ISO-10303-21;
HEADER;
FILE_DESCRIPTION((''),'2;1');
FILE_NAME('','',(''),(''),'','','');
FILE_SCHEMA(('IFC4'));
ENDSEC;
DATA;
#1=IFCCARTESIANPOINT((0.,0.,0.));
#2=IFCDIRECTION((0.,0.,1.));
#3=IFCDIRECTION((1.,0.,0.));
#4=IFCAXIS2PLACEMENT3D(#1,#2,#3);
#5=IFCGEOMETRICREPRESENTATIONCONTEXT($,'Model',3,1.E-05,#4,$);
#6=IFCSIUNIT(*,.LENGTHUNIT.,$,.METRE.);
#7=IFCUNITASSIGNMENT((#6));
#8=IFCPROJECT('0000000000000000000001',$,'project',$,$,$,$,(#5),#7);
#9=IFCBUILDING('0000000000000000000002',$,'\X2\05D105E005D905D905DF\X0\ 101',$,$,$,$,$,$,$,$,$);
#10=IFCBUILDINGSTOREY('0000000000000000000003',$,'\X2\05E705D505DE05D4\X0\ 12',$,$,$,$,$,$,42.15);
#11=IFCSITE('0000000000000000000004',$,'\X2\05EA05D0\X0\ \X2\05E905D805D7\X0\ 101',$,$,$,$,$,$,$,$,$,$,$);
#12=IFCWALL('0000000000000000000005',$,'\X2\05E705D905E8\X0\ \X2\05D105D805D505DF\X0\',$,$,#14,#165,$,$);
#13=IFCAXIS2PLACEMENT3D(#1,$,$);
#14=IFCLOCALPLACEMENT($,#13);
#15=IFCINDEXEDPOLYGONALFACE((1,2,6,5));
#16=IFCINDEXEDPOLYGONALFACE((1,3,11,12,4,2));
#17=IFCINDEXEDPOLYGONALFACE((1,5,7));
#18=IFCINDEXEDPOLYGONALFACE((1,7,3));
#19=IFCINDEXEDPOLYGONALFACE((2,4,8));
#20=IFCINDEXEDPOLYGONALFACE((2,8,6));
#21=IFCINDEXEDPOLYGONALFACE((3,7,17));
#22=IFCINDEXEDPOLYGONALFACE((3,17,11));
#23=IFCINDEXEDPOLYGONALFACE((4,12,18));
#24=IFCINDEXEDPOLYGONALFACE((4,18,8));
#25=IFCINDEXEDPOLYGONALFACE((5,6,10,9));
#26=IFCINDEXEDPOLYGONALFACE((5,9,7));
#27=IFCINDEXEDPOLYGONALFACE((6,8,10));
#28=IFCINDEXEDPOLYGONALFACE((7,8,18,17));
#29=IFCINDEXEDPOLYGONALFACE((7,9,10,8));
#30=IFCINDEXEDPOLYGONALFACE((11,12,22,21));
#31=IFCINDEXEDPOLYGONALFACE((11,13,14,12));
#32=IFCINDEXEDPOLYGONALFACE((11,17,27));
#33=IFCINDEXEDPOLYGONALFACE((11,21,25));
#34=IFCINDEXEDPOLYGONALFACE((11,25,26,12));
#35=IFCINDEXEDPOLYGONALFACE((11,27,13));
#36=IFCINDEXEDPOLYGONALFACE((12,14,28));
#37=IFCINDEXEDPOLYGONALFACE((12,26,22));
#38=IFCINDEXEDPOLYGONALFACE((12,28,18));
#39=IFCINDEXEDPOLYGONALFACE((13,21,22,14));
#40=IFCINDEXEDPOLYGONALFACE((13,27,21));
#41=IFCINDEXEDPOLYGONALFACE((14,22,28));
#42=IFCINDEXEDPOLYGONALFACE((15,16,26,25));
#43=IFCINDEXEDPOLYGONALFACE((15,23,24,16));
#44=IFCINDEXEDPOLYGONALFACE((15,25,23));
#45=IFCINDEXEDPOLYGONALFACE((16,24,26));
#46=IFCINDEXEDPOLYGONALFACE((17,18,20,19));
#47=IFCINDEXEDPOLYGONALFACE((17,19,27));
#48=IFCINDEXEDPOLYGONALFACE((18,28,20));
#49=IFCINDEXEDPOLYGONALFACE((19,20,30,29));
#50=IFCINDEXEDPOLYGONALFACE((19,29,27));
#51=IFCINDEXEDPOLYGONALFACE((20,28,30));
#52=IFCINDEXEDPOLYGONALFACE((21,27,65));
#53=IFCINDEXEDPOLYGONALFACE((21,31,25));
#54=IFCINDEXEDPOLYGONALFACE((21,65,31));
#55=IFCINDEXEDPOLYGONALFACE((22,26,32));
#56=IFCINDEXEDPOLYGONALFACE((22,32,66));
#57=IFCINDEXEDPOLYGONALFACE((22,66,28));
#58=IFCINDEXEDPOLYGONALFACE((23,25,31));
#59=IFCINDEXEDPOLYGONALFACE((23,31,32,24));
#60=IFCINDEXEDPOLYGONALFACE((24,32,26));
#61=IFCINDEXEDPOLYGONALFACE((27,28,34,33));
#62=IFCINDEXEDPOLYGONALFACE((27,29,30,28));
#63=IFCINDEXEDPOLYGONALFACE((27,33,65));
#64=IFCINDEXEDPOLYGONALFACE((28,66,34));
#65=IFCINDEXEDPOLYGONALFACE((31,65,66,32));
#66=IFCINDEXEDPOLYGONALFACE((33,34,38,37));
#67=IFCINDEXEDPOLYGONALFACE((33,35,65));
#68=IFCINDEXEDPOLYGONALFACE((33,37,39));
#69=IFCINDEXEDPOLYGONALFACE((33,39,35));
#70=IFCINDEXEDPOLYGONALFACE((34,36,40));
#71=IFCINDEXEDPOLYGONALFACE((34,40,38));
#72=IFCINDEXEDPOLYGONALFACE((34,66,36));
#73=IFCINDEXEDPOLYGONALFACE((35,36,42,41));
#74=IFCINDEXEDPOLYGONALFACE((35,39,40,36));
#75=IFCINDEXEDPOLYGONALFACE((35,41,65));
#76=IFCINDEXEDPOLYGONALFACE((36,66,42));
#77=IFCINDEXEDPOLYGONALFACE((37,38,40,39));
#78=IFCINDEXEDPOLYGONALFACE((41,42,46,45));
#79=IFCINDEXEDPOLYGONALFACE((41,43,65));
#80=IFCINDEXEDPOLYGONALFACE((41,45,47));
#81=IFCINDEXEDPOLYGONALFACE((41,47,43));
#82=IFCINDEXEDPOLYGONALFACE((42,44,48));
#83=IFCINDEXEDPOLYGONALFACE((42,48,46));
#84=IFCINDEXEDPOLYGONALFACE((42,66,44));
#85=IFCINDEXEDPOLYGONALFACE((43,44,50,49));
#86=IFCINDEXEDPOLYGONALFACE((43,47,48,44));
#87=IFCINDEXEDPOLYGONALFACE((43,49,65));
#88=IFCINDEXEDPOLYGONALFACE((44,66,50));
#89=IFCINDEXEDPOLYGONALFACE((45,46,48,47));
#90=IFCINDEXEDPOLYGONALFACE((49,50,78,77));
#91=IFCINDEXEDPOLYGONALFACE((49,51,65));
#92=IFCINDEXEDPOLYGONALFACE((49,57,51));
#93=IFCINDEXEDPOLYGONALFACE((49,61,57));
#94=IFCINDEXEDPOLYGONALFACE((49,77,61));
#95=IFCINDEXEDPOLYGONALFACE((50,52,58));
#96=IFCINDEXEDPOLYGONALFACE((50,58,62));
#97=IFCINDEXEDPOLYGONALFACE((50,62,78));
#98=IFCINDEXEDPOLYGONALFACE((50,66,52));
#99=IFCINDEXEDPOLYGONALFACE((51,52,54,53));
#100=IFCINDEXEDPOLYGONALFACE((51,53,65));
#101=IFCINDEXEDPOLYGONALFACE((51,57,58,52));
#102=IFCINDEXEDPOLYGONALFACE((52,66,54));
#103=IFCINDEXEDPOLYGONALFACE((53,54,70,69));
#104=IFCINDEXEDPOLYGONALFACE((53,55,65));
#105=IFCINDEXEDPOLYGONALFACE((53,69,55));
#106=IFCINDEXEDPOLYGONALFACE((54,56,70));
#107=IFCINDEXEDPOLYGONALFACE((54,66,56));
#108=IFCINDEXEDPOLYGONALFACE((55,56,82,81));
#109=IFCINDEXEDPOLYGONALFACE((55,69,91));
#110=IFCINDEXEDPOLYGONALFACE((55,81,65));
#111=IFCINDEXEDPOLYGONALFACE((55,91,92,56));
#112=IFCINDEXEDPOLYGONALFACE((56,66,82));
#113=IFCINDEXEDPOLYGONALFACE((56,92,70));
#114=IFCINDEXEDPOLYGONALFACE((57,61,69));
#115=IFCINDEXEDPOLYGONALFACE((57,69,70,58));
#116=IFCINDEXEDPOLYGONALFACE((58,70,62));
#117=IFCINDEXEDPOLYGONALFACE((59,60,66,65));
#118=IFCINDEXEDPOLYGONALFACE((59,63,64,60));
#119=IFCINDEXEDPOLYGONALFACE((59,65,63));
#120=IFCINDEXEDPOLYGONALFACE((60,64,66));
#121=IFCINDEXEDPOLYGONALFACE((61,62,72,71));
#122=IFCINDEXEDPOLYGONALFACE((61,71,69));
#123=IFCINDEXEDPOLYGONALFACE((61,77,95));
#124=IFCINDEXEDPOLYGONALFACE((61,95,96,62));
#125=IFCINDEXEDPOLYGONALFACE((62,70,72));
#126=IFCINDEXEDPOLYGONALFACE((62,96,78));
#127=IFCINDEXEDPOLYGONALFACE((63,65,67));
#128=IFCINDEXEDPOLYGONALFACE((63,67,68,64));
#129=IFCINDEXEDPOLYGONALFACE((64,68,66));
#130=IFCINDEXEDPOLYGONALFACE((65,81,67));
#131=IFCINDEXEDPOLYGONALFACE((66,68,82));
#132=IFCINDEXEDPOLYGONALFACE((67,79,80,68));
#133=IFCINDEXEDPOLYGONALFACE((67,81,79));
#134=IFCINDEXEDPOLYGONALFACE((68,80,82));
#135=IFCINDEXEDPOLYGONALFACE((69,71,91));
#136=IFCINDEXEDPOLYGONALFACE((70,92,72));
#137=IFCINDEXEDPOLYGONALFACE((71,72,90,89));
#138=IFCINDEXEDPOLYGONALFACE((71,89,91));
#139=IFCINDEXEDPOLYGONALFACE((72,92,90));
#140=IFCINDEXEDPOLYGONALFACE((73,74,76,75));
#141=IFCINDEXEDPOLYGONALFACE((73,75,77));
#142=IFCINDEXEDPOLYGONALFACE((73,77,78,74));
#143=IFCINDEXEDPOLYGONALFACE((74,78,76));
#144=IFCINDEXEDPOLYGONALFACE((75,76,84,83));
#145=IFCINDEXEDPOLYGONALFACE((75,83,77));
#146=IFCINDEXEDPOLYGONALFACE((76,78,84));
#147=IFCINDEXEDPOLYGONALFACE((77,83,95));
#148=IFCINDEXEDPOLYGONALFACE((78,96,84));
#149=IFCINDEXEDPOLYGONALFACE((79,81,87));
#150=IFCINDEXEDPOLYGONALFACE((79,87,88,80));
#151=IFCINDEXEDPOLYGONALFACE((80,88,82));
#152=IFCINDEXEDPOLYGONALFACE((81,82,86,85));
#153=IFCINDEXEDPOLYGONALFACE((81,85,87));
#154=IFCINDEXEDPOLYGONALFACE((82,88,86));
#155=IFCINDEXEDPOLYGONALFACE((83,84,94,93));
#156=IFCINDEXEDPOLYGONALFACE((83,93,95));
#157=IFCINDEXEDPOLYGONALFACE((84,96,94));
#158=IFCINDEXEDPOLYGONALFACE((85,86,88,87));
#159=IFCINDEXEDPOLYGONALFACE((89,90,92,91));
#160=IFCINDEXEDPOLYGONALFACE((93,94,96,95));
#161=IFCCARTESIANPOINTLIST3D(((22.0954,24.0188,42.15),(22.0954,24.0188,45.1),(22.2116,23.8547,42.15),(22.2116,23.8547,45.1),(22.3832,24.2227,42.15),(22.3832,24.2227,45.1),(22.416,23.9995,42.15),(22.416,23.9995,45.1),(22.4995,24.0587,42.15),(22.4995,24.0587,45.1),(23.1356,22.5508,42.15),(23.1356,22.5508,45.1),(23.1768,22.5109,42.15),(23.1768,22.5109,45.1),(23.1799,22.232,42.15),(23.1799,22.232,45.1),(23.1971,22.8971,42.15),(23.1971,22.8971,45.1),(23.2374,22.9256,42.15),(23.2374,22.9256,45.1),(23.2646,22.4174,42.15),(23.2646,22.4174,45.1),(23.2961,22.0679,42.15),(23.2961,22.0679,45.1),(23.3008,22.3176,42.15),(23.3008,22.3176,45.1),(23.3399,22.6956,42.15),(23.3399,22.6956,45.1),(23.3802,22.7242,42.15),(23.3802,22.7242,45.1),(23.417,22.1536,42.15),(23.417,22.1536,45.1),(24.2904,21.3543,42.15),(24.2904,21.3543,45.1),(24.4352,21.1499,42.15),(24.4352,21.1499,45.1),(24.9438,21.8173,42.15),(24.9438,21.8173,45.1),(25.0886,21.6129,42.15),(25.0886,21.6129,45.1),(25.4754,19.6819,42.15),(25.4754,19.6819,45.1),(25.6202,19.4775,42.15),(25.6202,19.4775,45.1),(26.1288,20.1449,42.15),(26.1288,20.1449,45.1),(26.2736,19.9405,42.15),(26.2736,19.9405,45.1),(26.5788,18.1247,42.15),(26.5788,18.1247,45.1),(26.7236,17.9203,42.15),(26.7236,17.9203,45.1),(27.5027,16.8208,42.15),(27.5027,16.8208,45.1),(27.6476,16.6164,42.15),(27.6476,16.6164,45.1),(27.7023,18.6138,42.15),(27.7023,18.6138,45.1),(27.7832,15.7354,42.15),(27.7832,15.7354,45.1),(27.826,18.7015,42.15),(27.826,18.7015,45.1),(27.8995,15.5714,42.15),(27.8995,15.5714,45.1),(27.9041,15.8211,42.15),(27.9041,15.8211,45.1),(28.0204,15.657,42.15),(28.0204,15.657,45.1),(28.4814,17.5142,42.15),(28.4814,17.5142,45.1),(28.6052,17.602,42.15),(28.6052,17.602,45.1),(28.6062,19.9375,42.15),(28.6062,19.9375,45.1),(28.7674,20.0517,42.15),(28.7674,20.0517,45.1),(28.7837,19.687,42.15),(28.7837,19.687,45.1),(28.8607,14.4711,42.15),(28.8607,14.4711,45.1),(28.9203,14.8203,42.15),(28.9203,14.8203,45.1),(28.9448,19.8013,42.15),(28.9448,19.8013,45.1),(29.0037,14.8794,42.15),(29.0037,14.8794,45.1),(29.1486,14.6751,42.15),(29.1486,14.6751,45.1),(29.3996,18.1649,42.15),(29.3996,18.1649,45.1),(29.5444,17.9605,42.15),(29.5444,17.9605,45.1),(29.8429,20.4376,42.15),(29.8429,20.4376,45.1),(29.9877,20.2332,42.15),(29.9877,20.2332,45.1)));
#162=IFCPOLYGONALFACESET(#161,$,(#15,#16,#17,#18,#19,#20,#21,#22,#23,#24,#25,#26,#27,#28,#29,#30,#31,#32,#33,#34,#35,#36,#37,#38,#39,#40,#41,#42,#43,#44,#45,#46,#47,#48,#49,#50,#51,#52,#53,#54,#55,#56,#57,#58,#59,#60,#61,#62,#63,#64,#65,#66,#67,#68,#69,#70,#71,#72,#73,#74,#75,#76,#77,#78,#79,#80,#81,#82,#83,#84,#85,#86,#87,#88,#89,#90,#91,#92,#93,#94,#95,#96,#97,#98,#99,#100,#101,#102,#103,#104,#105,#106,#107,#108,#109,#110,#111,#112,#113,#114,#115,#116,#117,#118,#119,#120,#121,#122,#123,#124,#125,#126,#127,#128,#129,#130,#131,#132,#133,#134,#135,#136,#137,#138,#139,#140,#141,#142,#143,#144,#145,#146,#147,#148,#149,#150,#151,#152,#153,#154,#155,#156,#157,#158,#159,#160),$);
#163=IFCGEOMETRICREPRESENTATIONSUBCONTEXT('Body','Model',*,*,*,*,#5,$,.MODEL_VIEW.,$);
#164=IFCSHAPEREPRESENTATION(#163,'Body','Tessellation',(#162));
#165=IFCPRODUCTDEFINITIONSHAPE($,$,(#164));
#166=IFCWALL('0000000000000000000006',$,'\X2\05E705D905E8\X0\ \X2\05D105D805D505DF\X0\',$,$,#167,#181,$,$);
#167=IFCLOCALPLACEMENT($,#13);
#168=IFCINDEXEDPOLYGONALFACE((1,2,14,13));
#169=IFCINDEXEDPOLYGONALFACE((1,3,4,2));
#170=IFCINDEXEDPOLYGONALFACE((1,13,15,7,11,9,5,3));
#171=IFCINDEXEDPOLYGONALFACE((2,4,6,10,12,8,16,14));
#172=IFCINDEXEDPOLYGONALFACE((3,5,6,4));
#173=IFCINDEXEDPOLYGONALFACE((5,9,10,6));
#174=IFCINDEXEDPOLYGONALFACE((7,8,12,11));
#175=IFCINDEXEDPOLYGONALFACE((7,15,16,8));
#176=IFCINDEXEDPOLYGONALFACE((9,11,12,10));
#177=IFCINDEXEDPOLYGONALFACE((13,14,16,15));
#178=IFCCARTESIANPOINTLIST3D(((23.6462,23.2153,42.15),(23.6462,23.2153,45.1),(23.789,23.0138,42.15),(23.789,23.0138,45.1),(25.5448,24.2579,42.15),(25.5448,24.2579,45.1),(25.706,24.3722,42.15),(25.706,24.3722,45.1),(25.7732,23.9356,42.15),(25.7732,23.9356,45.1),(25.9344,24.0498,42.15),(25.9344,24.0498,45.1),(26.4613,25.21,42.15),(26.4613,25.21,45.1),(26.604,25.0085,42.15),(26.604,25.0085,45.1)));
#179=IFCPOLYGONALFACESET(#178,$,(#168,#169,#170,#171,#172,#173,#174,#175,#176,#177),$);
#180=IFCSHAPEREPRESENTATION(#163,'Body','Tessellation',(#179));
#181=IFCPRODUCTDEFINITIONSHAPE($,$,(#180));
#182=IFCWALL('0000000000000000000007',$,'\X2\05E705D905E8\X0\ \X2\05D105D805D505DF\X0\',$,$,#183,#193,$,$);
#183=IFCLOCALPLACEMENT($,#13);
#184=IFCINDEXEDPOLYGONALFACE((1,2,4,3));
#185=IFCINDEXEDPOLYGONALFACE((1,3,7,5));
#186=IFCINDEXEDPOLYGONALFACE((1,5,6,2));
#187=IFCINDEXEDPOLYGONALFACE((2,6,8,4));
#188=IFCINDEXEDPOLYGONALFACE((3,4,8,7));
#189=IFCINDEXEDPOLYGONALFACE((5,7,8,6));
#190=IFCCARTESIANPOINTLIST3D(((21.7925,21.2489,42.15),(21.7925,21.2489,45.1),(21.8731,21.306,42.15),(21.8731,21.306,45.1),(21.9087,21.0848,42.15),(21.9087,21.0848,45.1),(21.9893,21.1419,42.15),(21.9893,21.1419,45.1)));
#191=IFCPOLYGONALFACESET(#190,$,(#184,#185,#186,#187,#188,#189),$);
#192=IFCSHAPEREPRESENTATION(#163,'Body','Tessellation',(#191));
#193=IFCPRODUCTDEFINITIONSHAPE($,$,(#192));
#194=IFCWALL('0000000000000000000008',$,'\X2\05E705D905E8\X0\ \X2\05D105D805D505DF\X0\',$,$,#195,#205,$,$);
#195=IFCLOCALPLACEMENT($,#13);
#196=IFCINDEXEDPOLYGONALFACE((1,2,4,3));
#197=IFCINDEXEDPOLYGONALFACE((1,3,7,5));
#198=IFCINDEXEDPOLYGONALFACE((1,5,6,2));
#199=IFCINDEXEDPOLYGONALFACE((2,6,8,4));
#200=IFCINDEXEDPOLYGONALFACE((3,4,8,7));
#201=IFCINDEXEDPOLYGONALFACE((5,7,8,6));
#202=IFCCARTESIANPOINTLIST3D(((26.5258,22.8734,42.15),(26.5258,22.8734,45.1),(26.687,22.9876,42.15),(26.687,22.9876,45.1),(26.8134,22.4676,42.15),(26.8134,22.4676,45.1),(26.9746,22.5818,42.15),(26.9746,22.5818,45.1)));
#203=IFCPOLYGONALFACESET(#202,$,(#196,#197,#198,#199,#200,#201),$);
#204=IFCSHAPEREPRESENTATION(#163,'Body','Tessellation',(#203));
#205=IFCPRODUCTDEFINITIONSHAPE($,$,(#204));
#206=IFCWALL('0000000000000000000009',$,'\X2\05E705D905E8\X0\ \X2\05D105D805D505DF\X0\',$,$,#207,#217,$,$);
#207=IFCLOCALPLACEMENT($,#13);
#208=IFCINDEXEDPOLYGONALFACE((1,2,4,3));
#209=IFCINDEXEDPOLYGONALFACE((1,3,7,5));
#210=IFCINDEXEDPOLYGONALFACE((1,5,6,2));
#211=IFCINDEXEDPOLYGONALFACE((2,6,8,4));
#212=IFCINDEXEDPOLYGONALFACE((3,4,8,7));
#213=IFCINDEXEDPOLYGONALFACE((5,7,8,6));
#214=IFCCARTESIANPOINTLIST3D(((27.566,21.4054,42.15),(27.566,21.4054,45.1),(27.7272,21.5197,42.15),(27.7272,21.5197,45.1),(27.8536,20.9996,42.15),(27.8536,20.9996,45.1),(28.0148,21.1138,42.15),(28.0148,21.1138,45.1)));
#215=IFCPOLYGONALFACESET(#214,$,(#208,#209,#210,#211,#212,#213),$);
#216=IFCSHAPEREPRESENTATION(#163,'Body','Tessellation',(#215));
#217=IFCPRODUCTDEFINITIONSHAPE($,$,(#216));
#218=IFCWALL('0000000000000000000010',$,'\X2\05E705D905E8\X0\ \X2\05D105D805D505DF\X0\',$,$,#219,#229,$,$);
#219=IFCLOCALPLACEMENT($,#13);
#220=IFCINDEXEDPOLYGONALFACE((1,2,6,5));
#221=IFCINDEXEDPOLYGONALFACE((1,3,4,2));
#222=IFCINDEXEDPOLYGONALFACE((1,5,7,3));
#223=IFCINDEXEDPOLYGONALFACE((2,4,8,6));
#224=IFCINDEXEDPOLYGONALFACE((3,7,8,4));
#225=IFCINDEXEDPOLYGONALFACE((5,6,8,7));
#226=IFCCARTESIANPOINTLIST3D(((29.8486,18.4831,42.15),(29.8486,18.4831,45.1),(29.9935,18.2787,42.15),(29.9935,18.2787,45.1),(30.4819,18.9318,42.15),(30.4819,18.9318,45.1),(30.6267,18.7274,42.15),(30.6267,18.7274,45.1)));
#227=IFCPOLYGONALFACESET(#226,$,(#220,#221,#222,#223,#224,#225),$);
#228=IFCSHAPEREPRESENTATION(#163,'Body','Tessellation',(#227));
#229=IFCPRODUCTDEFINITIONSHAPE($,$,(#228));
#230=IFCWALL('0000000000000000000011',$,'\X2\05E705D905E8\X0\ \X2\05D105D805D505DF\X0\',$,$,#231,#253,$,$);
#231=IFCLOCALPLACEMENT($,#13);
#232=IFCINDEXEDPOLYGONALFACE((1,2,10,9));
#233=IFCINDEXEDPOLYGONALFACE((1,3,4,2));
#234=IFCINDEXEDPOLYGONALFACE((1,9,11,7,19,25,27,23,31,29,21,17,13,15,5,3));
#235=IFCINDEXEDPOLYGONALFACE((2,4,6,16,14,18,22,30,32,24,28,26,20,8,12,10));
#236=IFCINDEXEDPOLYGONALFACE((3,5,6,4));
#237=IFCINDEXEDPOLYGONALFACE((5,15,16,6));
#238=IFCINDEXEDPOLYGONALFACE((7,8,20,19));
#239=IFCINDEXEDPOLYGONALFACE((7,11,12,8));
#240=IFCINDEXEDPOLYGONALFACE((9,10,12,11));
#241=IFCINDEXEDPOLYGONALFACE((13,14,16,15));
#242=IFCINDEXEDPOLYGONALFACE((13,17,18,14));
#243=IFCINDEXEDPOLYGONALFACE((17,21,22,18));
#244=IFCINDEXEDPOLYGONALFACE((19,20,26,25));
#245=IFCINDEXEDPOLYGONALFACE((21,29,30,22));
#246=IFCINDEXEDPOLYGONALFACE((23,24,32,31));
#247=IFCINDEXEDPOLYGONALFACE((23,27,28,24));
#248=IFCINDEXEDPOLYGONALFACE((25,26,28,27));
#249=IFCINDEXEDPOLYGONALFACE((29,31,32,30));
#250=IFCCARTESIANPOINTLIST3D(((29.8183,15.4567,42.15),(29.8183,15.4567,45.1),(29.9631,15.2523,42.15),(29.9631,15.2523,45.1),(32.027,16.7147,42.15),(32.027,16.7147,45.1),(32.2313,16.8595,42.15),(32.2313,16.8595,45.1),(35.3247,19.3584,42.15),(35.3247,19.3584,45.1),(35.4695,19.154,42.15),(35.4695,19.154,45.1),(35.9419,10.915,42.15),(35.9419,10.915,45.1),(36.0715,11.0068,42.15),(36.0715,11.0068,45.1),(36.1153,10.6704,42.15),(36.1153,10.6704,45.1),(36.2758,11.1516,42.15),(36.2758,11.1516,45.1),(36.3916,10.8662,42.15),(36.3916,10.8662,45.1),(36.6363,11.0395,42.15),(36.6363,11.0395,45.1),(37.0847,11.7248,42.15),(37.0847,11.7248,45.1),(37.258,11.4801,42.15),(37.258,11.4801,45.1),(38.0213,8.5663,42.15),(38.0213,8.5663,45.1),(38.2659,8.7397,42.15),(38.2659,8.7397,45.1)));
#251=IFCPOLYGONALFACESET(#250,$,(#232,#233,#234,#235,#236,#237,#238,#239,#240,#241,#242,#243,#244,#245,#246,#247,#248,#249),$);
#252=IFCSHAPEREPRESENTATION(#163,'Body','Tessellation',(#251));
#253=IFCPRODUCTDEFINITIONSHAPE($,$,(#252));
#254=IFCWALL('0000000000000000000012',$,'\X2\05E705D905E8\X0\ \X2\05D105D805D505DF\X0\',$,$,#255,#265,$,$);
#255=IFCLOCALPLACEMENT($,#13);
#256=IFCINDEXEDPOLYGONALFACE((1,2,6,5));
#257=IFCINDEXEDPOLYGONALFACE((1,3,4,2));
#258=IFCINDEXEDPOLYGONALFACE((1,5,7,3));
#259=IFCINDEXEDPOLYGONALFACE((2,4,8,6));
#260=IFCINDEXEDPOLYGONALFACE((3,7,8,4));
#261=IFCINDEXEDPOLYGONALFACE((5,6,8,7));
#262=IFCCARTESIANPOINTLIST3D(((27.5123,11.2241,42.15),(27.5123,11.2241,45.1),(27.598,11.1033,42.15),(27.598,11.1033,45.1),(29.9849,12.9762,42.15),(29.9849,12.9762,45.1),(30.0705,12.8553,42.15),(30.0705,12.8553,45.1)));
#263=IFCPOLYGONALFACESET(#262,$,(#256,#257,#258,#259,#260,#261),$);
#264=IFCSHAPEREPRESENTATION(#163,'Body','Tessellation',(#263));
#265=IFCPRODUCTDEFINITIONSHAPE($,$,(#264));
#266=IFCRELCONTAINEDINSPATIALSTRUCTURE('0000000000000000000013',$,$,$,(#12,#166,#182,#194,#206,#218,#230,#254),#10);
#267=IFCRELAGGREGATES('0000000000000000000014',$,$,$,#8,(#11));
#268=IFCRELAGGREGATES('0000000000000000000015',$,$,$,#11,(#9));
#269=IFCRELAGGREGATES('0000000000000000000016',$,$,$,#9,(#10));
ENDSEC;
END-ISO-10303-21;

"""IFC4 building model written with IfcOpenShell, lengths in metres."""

from ifc_helpers import new_model, si_unit, frame, origin_with_axes, context, subcontext, project, spatial, polyline, outline, extrude, element, save


model = new_model("IFC4")

# Units and contexts
model_context = context("Model", 3, precision=1e-05, world=origin_with_axes())
body_context = subcontext(model_context, "Body", "Model", "MODEL_VIEW")
ifc_project = project(units=[si_unit("LENGTHUNIT", "METRE")], contexts=[model_context])

# Site, building, storey
site = spatial("IfcSite", under=ifc_project, Name="תא שטח 101")
building = spatial("IfcBuilding", under=site, Name="בניין 101")
storey = spatial("IfcBuildingStorey", under=building, Name="קומה 12", Elevation=42.15)

# Walls
element("IfcWall", 1, inside=storey, Name="קיר בטון", context=body_context, shape_type="SweptSolid", body=[
    extrude(outline(polyline([(23.1799, 22.232), (23.2961, 22.0679), (23.417, 22.1536), (27.9041, 15.8211), (27.7832, 15.7354), (27.8995, 15.5714), (28.0204, 15.657), (28.8607, 14.4711), (29.1486, 14.6751), (29.0037, 14.8794), (28.9203, 14.8203), (27.6476, 16.6164), (29.5444, 17.9605), (29.3996, 18.1649), (28.6052, 17.602), (27.826, 18.7015), (29.9877, 20.2332), (29.8429, 20.4376), (28.9448, 19.8013), (28.7674, 20.0517), (28.6062, 19.9375), (28.7837, 19.687), (26.5788, 18.1247), (25.6202, 19.4775), (26.2736, 19.9405), (26.1288, 20.1449), (25.4754, 19.6819), (24.4352, 21.1499), (25.0886, 21.6129), (24.9438, 21.8173), (24.2904, 21.3543), (23.3399, 22.6956), (23.3802, 22.7242), (23.2374, 22.9256), (23.1971, 22.8971), (22.416, 23.9995), (22.4995, 24.0587), (22.3832, 24.2227), (22.0954, 24.0188), (22.2116, 23.8547), (23.1356, 22.5508), (23.3008, 22.3176), (23.1799, 22.232)]), holes=[polyline([(23.1768, 22.5109), (23.2646, 22.4174), (23.1356, 22.5508), (23.1768, 22.5109)]), polyline([(26.7236, 17.9203), (27.7023, 18.6138), (28.4814, 17.5142), (27.5027, 16.8208), (26.7236, 17.9203)])]), frame((0.0, 0.0, 42.15)), (0.0, 0.0, 1.0), 2.95),
])
element("IfcWall", 2, inside=storey, Name="קיר בטון", context=body_context, shape_type="SweptSolid", body=[
    extrude(outline(polyline([(25.9344, 24.0498), (25.706, 24.3722), (26.604, 25.0085), (26.4613, 25.21), (23.6462, 23.2153), (23.789, 23.0138), (25.5448, 24.2579), (25.7732, 23.9356), (25.9344, 24.0498)])), frame((0.0, 0.0, 42.15)), (0.0, 0.0, 1.0), 2.95),
])
element("IfcWall", 3, inside=storey, Name="קיר בטון", context=body_context, shape_type="SweptSolid", body=[
    extrude(outline(polyline([(21.8731, 21.306), (21.7925, 21.2489), (21.9087, 21.0848), (21.9893, 21.1419), (21.8731, 21.306)])), frame((0.0, 0.0, 42.15)), (0.0, 0.0, 1.0), 2.95),
])
element("IfcWall", 4, inside=storey, Name="קיר בטון", context=body_context, shape_type="SweptSolid", body=[
    extrude(outline(polyline([(26.9746, 22.5818), (26.687, 22.9876), (26.5258, 22.8734), (26.8134, 22.4676), (26.9746, 22.5818)])), frame((0.0, 0.0, 42.15)), (0.0, 0.0, 1.0), 2.95),
])
element("IfcWall", 5, inside=storey, Name="קיר בטון", context=body_context, shape_type="SweptSolid", body=[
    extrude(outline(polyline([(27.8536, 20.9996), (28.0148, 21.1138), (27.7272, 21.5197), (27.566, 21.4054), (27.8536, 20.9996)])), frame((0.0, 0.0, 42.15)), (0.0, 0.0, 1.0), 2.95),
])
element("IfcWall", 6, inside=storey, Name="קיר בטון", context=body_context, shape_type="SweptSolid", body=[
    extrude(outline(polyline([(29.9935, 18.2787), (30.6267, 18.7274), (30.4819, 18.9318), (29.8486, 18.4831), (29.9935, 18.2787)])), frame((0.0, 0.0, 42.15)), (0.0, 0.0, 1.0), 2.95),
])
element("IfcWall", 7, inside=storey, Name="קיר בטון", context=body_context, shape_type="SweptSolid", body=[
    extrude(outline(polyline([(29.8183, 15.4567), (29.9631, 15.2523), (32.027, 16.7147), (36.0715, 11.0068), (35.9419, 10.915), (36.1153, 10.6704), (36.3916, 10.8662), (38.0213, 8.5663), (38.2659, 8.7397), (36.6363, 11.0395), (37.258, 11.4801), (37.0847, 11.7248), (36.2758, 11.1516), (32.2313, 16.8595), (35.4695, 19.154), (35.3247, 19.3584), (29.8183, 15.4567)])), frame((0.0, 0.0, 42.15)), (0.0, 0.0, 1.0), 2.95),
])
element("IfcWall", 8, inside=storey, Name="קיר בטון", context=body_context, shape_type="SweptSolid", body=[
    extrude(outline(polyline([(30.0705, 12.8553), (29.9849, 12.9762), (27.5123, 11.2241), (27.598, 11.1033), (30.0705, 12.8553)])), frame((0.0, 0.0, 42.15)), (0.0, 0.0, 1.0), 2.95),
])

save(model, "model.ifc")
